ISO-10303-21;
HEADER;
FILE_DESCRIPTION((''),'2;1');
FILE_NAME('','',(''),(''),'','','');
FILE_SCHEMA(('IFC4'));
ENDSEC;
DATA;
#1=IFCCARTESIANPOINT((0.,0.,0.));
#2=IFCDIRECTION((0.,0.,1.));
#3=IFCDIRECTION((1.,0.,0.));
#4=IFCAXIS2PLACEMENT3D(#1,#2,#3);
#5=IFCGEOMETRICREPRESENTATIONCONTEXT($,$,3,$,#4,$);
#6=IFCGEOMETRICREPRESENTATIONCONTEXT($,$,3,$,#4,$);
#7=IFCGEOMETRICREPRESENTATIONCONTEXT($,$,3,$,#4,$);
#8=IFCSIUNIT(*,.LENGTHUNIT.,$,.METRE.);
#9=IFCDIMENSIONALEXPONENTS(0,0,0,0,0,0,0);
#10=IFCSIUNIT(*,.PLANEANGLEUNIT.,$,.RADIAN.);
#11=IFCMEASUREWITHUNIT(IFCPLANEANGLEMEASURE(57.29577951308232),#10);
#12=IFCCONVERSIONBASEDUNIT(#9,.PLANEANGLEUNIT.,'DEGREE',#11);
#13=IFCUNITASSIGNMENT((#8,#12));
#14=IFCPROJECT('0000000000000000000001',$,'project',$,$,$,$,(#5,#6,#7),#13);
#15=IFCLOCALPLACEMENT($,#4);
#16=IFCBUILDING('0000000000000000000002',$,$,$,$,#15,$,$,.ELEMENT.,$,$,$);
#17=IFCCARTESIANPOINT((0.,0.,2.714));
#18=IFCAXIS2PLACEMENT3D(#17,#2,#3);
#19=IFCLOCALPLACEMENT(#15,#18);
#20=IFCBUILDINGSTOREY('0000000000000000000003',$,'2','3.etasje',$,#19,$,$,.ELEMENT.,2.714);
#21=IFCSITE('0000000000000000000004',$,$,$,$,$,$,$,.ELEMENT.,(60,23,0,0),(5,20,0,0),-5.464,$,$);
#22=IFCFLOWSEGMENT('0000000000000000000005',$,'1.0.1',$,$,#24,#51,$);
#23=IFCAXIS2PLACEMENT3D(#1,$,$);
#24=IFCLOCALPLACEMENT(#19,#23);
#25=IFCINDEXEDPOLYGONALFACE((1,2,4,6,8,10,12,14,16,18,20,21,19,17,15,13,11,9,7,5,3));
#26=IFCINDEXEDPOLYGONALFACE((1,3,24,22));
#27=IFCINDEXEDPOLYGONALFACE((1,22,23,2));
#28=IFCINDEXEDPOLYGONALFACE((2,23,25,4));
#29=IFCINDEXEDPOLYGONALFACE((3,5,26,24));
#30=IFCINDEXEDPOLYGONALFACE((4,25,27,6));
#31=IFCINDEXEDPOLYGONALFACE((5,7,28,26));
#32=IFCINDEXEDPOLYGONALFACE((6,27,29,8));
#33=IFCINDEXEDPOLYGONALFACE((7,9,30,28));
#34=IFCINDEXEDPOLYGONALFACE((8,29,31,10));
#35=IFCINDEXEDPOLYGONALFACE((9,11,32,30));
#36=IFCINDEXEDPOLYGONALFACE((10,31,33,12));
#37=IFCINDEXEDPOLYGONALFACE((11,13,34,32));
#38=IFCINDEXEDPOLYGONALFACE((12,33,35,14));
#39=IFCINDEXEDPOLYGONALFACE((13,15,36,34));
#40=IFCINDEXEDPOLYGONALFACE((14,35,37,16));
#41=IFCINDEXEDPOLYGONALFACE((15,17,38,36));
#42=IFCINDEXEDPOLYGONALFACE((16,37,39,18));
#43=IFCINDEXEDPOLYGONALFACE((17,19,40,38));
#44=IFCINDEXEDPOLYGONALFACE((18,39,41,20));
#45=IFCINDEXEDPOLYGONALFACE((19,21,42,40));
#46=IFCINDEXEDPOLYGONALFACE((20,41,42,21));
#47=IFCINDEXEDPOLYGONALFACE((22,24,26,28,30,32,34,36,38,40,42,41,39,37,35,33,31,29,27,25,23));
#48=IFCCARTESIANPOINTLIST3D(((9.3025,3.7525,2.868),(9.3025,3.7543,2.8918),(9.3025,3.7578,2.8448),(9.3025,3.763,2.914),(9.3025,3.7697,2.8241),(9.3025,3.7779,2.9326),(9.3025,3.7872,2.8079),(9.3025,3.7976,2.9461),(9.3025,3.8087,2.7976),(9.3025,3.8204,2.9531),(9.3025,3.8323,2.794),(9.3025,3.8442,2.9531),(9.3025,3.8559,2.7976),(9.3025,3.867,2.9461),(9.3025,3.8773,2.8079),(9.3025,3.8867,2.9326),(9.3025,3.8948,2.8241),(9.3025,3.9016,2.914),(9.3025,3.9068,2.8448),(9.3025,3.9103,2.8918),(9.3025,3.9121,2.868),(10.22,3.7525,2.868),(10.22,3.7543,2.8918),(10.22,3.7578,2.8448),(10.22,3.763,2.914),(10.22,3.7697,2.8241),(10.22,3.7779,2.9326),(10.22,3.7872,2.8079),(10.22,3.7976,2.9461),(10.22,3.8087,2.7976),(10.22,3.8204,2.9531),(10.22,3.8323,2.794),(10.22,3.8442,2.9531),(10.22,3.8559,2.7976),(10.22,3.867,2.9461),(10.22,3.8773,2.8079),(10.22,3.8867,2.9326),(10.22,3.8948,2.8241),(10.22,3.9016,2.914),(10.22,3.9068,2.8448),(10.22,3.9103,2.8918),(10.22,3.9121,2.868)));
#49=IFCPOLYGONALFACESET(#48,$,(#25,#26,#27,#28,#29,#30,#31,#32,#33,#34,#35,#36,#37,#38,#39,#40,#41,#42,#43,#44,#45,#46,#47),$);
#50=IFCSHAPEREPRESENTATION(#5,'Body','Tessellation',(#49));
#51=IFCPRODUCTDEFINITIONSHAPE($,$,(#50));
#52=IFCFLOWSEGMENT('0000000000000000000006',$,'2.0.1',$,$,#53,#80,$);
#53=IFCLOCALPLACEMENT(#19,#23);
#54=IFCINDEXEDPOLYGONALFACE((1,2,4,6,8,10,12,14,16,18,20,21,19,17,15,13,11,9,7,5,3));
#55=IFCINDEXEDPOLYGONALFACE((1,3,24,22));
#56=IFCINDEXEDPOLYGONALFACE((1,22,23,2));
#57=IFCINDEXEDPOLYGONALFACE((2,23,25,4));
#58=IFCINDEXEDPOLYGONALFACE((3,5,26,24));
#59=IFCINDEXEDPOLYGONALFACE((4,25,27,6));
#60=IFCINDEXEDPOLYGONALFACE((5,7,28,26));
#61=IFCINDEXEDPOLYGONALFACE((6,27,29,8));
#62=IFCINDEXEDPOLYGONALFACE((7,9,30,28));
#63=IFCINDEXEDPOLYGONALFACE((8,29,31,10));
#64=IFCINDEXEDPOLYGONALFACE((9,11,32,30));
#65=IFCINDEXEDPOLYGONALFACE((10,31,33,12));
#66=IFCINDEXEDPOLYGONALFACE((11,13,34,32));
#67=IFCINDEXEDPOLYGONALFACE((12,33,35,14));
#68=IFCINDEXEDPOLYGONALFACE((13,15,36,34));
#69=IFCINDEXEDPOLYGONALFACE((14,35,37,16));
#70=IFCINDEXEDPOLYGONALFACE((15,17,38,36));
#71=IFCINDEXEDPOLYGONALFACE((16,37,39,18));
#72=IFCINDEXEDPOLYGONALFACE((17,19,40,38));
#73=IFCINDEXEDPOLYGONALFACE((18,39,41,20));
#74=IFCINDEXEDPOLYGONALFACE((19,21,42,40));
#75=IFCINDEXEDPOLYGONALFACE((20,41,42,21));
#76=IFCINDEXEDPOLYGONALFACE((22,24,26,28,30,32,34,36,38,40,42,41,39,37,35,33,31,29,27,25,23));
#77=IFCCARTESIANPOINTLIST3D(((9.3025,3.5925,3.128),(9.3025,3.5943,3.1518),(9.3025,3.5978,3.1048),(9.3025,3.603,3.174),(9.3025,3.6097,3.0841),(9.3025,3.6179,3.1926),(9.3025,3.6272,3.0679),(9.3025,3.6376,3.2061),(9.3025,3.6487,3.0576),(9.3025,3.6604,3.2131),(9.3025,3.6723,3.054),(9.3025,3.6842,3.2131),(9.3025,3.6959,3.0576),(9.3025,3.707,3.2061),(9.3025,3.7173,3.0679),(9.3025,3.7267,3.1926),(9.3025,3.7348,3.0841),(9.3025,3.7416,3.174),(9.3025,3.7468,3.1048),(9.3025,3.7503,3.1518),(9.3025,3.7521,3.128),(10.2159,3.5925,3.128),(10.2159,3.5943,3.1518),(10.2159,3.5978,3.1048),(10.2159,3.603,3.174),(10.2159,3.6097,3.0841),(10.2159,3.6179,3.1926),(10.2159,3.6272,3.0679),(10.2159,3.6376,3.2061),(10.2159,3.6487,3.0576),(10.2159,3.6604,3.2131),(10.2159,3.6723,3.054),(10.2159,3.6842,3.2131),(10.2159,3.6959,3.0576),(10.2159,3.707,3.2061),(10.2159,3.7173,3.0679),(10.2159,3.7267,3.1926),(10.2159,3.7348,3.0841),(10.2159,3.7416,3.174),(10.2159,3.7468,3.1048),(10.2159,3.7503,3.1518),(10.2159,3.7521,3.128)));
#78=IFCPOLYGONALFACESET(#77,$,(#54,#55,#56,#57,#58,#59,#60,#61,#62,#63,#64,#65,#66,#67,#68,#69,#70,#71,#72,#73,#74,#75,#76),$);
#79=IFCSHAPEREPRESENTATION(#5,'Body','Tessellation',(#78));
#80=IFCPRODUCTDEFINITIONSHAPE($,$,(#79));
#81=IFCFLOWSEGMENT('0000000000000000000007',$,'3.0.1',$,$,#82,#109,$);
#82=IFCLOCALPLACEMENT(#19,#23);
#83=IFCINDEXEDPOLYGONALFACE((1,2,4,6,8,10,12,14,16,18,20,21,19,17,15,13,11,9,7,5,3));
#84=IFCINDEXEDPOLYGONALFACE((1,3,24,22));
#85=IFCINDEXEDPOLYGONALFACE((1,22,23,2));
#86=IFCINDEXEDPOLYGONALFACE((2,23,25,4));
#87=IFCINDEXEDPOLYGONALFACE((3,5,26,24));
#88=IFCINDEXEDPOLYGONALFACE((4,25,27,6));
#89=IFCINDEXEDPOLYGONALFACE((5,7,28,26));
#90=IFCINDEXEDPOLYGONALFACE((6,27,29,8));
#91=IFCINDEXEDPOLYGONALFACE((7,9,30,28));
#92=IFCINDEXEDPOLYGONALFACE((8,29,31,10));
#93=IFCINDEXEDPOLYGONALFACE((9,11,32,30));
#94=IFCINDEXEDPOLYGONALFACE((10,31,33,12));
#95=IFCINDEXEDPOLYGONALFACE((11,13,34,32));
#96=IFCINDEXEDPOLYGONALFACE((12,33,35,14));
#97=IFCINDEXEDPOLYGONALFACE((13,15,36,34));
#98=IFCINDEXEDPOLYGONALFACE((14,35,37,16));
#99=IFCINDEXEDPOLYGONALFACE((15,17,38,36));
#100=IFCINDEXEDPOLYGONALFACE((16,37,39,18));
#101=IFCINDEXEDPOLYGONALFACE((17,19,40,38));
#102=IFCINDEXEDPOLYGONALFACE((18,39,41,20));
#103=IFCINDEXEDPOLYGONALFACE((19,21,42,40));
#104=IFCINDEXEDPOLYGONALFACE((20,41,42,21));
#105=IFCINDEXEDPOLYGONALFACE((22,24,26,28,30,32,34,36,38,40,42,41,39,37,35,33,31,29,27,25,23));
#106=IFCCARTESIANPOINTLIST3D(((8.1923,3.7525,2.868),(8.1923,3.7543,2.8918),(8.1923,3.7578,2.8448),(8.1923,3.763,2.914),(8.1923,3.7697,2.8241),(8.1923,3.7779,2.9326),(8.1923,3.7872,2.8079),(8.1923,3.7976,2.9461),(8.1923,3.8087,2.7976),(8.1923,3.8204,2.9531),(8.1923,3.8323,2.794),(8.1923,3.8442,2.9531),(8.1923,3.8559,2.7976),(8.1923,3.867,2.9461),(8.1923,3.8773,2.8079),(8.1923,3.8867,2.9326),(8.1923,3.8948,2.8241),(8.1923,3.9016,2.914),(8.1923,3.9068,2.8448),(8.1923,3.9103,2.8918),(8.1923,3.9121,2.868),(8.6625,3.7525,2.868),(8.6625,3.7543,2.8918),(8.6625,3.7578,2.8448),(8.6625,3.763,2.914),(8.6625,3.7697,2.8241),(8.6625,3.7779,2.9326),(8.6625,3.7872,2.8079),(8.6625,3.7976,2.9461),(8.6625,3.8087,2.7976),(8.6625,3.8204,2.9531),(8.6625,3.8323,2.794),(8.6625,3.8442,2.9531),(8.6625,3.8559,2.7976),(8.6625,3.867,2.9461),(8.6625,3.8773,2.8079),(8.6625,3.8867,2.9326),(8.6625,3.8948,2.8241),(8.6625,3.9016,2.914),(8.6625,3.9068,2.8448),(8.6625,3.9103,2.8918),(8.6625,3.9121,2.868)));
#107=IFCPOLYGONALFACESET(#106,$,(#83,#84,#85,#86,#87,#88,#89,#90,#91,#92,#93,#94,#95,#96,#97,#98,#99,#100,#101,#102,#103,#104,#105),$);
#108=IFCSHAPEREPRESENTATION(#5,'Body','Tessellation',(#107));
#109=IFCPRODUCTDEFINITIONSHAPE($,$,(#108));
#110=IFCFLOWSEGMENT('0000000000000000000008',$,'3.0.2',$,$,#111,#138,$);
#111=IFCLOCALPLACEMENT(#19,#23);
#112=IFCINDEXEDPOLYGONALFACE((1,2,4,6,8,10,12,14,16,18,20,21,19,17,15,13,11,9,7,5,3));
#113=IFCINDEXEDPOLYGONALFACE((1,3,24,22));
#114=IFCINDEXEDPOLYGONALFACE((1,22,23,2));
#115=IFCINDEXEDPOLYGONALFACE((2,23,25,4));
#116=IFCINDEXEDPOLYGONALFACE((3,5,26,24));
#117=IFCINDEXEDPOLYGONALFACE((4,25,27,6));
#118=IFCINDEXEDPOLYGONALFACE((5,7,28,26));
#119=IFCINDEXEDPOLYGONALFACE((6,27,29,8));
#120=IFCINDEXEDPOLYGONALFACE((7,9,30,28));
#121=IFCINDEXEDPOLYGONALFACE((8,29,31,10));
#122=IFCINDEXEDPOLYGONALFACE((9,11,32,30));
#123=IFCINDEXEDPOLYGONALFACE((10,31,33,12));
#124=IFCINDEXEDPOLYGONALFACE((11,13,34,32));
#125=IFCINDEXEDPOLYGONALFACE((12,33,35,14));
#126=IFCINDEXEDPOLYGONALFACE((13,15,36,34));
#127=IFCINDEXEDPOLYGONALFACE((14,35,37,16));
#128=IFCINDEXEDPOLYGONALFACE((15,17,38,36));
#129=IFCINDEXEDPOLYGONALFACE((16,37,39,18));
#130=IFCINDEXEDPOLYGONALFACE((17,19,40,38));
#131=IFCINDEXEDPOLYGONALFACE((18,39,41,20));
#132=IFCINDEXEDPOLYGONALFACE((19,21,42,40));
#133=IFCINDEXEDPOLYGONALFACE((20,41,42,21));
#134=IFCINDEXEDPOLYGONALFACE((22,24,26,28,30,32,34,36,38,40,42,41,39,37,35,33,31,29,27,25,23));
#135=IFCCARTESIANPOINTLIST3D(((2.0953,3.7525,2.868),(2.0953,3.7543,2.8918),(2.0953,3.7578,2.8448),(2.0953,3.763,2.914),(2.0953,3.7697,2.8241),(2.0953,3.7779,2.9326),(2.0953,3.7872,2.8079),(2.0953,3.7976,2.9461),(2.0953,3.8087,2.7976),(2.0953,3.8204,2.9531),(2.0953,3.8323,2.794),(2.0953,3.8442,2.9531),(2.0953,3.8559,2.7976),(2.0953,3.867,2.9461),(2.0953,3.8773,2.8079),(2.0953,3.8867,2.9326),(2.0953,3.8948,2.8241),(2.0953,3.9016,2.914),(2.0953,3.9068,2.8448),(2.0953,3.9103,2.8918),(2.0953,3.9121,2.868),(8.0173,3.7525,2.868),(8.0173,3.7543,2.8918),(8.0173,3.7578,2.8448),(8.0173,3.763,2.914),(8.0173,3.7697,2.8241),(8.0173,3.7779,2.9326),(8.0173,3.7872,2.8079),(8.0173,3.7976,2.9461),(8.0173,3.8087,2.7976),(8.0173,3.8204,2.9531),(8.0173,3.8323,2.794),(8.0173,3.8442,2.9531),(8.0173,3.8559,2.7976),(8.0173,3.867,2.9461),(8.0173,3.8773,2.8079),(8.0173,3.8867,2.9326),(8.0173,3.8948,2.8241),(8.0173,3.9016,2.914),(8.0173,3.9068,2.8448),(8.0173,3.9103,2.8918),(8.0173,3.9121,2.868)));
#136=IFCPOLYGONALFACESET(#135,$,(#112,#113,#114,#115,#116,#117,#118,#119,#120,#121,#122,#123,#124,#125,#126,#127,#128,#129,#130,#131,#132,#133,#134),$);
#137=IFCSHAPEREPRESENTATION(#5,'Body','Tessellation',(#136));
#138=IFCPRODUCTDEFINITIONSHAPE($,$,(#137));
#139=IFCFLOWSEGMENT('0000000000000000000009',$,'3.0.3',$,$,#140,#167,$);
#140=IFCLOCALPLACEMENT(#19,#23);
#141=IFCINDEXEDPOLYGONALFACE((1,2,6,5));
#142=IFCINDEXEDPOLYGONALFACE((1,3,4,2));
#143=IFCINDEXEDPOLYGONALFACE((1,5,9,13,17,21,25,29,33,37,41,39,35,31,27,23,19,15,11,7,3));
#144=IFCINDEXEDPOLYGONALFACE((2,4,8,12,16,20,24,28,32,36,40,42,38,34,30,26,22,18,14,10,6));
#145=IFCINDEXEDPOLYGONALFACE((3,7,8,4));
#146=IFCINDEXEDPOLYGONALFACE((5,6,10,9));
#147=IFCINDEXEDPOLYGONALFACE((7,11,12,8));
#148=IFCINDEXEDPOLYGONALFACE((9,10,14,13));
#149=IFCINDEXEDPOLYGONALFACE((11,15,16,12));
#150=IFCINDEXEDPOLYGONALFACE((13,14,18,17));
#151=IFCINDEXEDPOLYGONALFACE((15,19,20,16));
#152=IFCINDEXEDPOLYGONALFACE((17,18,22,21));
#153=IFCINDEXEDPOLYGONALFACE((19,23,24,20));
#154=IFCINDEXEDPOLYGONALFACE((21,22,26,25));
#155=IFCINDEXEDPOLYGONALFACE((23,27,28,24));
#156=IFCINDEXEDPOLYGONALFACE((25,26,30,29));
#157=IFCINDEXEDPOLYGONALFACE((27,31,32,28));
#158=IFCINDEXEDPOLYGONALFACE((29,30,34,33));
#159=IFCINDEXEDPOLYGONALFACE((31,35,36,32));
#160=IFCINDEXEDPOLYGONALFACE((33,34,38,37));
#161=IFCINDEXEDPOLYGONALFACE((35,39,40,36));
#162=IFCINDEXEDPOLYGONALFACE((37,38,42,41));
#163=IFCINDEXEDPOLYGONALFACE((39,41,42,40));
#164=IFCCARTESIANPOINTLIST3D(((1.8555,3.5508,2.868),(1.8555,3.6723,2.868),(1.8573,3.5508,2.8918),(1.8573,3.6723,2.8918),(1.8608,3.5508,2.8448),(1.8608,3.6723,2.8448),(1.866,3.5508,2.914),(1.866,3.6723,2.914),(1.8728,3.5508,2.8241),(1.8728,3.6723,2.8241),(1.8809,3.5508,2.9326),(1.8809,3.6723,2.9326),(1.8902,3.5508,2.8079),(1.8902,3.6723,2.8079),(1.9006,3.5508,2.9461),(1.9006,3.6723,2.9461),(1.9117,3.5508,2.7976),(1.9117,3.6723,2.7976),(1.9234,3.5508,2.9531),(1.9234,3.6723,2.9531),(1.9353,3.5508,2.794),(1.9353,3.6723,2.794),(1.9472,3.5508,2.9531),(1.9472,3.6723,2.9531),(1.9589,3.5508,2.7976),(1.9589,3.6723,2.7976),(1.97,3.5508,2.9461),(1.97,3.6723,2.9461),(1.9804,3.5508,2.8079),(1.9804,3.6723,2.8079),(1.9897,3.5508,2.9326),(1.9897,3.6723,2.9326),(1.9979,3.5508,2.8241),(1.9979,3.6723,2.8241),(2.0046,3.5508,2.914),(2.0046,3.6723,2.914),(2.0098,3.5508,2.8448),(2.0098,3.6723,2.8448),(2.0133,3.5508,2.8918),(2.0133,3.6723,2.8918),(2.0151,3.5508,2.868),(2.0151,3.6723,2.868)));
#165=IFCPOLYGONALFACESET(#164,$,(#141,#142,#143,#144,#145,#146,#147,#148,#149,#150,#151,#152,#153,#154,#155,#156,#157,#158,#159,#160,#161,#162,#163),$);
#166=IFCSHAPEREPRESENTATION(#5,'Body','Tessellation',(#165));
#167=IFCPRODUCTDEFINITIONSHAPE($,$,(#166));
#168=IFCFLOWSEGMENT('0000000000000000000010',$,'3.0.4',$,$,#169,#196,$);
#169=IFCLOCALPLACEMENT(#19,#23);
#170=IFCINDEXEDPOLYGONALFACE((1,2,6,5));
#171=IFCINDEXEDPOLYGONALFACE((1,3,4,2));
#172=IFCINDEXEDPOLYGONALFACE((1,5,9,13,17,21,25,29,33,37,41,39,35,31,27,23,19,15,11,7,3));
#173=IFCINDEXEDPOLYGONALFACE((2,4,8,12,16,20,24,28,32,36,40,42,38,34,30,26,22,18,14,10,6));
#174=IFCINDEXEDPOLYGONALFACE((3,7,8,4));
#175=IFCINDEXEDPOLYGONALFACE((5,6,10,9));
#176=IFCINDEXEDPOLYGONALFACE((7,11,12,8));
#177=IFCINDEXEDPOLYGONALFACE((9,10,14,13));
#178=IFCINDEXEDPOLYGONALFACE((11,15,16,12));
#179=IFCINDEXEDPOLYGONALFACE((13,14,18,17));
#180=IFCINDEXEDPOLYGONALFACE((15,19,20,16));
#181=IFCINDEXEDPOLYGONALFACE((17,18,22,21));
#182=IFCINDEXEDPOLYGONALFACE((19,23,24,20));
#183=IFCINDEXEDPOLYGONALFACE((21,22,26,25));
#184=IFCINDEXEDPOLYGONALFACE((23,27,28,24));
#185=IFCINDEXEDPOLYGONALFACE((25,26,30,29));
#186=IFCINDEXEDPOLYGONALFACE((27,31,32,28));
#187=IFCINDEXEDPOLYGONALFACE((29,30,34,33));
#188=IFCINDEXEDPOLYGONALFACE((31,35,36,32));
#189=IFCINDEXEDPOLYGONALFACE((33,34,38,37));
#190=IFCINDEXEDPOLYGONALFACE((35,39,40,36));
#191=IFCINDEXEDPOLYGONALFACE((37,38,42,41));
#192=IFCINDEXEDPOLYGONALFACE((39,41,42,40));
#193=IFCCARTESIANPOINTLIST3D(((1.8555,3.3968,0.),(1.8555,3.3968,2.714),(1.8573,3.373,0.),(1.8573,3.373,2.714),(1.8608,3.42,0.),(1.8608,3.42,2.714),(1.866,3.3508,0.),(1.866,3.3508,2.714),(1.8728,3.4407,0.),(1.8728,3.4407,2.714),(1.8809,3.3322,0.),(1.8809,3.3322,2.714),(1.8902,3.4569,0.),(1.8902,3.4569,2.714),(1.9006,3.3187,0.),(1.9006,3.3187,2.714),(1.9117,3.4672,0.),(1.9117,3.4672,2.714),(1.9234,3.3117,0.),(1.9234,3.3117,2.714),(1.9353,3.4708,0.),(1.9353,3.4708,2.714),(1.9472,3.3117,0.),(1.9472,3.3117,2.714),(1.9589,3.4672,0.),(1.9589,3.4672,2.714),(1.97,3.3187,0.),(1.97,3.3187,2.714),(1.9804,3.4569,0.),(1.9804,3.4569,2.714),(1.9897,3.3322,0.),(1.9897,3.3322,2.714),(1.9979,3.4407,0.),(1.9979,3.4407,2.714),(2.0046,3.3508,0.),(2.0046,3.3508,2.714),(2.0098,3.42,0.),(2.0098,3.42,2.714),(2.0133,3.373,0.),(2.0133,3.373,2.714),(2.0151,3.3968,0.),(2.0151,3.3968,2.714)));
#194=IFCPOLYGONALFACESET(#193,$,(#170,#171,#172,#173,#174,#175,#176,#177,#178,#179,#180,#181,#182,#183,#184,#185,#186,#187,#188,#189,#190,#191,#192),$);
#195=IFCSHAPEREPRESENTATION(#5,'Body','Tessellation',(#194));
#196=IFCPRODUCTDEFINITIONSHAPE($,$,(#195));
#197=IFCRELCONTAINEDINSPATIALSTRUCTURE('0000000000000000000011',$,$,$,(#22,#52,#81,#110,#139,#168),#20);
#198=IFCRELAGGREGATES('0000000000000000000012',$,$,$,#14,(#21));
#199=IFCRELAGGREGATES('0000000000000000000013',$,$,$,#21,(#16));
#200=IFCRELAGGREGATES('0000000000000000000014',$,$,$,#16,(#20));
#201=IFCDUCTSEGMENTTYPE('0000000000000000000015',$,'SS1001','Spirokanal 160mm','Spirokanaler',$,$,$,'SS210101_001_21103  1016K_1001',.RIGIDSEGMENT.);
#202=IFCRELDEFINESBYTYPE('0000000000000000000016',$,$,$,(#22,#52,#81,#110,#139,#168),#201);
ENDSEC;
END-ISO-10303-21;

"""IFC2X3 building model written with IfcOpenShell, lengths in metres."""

from ifc_helpers import new_model, entity, si_unit, converted_unit, frame, origin_with_axes, origin_2d_with_axis, place, context, project, spatial, circle, extrude, type_object, element, save


model = new_model("IFC2X3")

# Units and contexts
context_of_model_1 = context(None, 3, world=origin_with_axes())
context_of_model_2 = context(None, 3, world=origin_with_axes())
context_of_model_3 = context(None, 3, world=origin_with_axes())
ifc_project = project(units=[si_unit("LENGTHUNIT", "METRE"), converted_unit("PLANEANGLEUNIT", "DEGREE", entity("IfcPlaneAngleMeasure", 57.29577951308232), si_unit("PLANEANGLEUNIT", "RADIAN"), dimensions=[0, 0, 0, 0, 0, 0, 0])], contexts=[context_of_model_1, context_of_model_2, context_of_model_3])

# Site, building, storey
site = spatial("IfcSite", under=ifc_project, CompositionType="ELEMENT", RefLatitude=(60, 23, 0, 0), RefLongitude=(5, 20, 0, 0), RefElevation=-5.464)
building_placement = place(None, origin_with_axes())
building = spatial("IfcBuilding", under=site, at=building_placement, CompositionType="ELEMENT")
storey_placement = place(building_placement, frame((0.0, 0.0, 2.714), z_axis=(0.0, 0.0, 1.0), x_axis=(1.0, 0.0, 0.0)))
storey = spatial("IfcBuildingStorey", under=building, at=storey_placement, Name="2", Description="3.etasje", CompositionType="ELEMENT", Elevation=2.714)

# Flow segments
duct_segment_type_1 = type_object("IfcDuctSegmentType", Name="SS1001", Description="Spirokanal 160mm", ApplicableOccurrence="Spirokanaler", ElementType="SS210101_001_21103  1016K_1001", PredefinedType="RIGIDSEGMENT")
flow_segment_1_placement = place(storey_placement, frame((9.3025, 3.8323, 2.874), z_axis=(1.0, 0.0, 0.0), x_axis=(0.0, 0.0, -1.0)))
element("IfcFlowSegment", 1, at=flow_segment_1_placement, inside=storey, type_object=duct_segment_type_1, Name="1.0.1", context=context_of_model_1, shape_type="SweptSolid", body=[
    extrude(circle(Radius=0.08, at=origin_2d_with_axis()), origin_with_axes(), (0.0, 0.0, 1.0), 0.9175),
])
flow_segment_2_placement = place(storey_placement, frame((9.3025, 3.6723, 3.134), z_axis=(1.0, 0.0, 0.0), x_axis=(0.0, 0.0, -1.0)))
element("IfcFlowSegment", 2, at=flow_segment_2_placement, inside=storey, type_object=duct_segment_type_1, Name="2.0.1", context=context_of_model_1, shape_type="SweptSolid", body=[
    extrude(circle(Radius=0.08, at=origin_2d_with_axis()), origin_with_axes(), (0.0, 0.0, 1.0), 0.9134),
])
flow_segment_3_placement = place(storey_placement, frame((8.6625, 3.8323, 2.874), z_axis=(-1.0, 0.0, 0.0), x_axis=(0.0, 0.0, -1.0)))
element("IfcFlowSegment", 3, at=flow_segment_3_placement, inside=storey, type_object=duct_segment_type_1, Name="3.0.1", context=context_of_model_1, shape_type="SweptSolid", body=[
    extrude(circle(Radius=0.08, at=origin_2d_with_axis()), origin_with_axes(), (0.0, 0.0, 1.0), 0.4702),
])
flow_segment_4_placement = place(storey_placement, frame((8.0173, 3.8323, 2.874), z_axis=(-1.0, 0.0, 0.0), x_axis=(0.0, 0.0, -1.0)))
element("IfcFlowSegment", 4, at=flow_segment_4_placement, inside=storey, type_object=duct_segment_type_1, Name="3.0.2", context=context_of_model_1, shape_type="SweptSolid", body=[
    extrude(circle(Radius=0.08, at=origin_2d_with_axis()), origin_with_axes(), (0.0, 0.0, 1.0), 5.922),
])
flow_segment_5_placement = place(storey_placement, frame((1.9353, 3.6723, 2.874), z_axis=(0.0, -1.0, 0.0), x_axis=(0.0, 0.0, -1.0)))
element("IfcFlowSegment", 5, at=flow_segment_5_placement, inside=storey, type_object=duct_segment_type_1, Name="3.0.3", context=context_of_model_1, shape_type="SweptSolid", body=[
    extrude(circle(Radius=0.08, at=origin_2d_with_axis()), origin_with_axes(), (0.0, 0.0, 1.0), 0.1215),
])
flow_segment_6_placement = place(storey_placement, frame((1.9353, 3.3908, 2.714), z_axis=(0.0, 0.0, -1.0), x_axis=(0.0, 1.0, 0.0)))
element("IfcFlowSegment", 6, at=flow_segment_6_placement, inside=storey, type_object=duct_segment_type_1, Name="3.0.4", context=context_of_model_1, shape_type="SweptSolid", body=[
    extrude(circle(Radius=0.08, at=origin_2d_with_axis()), origin_with_axes(), (0.0, 0.0, 1.0), 2.714),
])

save(model, "model.ifc")
